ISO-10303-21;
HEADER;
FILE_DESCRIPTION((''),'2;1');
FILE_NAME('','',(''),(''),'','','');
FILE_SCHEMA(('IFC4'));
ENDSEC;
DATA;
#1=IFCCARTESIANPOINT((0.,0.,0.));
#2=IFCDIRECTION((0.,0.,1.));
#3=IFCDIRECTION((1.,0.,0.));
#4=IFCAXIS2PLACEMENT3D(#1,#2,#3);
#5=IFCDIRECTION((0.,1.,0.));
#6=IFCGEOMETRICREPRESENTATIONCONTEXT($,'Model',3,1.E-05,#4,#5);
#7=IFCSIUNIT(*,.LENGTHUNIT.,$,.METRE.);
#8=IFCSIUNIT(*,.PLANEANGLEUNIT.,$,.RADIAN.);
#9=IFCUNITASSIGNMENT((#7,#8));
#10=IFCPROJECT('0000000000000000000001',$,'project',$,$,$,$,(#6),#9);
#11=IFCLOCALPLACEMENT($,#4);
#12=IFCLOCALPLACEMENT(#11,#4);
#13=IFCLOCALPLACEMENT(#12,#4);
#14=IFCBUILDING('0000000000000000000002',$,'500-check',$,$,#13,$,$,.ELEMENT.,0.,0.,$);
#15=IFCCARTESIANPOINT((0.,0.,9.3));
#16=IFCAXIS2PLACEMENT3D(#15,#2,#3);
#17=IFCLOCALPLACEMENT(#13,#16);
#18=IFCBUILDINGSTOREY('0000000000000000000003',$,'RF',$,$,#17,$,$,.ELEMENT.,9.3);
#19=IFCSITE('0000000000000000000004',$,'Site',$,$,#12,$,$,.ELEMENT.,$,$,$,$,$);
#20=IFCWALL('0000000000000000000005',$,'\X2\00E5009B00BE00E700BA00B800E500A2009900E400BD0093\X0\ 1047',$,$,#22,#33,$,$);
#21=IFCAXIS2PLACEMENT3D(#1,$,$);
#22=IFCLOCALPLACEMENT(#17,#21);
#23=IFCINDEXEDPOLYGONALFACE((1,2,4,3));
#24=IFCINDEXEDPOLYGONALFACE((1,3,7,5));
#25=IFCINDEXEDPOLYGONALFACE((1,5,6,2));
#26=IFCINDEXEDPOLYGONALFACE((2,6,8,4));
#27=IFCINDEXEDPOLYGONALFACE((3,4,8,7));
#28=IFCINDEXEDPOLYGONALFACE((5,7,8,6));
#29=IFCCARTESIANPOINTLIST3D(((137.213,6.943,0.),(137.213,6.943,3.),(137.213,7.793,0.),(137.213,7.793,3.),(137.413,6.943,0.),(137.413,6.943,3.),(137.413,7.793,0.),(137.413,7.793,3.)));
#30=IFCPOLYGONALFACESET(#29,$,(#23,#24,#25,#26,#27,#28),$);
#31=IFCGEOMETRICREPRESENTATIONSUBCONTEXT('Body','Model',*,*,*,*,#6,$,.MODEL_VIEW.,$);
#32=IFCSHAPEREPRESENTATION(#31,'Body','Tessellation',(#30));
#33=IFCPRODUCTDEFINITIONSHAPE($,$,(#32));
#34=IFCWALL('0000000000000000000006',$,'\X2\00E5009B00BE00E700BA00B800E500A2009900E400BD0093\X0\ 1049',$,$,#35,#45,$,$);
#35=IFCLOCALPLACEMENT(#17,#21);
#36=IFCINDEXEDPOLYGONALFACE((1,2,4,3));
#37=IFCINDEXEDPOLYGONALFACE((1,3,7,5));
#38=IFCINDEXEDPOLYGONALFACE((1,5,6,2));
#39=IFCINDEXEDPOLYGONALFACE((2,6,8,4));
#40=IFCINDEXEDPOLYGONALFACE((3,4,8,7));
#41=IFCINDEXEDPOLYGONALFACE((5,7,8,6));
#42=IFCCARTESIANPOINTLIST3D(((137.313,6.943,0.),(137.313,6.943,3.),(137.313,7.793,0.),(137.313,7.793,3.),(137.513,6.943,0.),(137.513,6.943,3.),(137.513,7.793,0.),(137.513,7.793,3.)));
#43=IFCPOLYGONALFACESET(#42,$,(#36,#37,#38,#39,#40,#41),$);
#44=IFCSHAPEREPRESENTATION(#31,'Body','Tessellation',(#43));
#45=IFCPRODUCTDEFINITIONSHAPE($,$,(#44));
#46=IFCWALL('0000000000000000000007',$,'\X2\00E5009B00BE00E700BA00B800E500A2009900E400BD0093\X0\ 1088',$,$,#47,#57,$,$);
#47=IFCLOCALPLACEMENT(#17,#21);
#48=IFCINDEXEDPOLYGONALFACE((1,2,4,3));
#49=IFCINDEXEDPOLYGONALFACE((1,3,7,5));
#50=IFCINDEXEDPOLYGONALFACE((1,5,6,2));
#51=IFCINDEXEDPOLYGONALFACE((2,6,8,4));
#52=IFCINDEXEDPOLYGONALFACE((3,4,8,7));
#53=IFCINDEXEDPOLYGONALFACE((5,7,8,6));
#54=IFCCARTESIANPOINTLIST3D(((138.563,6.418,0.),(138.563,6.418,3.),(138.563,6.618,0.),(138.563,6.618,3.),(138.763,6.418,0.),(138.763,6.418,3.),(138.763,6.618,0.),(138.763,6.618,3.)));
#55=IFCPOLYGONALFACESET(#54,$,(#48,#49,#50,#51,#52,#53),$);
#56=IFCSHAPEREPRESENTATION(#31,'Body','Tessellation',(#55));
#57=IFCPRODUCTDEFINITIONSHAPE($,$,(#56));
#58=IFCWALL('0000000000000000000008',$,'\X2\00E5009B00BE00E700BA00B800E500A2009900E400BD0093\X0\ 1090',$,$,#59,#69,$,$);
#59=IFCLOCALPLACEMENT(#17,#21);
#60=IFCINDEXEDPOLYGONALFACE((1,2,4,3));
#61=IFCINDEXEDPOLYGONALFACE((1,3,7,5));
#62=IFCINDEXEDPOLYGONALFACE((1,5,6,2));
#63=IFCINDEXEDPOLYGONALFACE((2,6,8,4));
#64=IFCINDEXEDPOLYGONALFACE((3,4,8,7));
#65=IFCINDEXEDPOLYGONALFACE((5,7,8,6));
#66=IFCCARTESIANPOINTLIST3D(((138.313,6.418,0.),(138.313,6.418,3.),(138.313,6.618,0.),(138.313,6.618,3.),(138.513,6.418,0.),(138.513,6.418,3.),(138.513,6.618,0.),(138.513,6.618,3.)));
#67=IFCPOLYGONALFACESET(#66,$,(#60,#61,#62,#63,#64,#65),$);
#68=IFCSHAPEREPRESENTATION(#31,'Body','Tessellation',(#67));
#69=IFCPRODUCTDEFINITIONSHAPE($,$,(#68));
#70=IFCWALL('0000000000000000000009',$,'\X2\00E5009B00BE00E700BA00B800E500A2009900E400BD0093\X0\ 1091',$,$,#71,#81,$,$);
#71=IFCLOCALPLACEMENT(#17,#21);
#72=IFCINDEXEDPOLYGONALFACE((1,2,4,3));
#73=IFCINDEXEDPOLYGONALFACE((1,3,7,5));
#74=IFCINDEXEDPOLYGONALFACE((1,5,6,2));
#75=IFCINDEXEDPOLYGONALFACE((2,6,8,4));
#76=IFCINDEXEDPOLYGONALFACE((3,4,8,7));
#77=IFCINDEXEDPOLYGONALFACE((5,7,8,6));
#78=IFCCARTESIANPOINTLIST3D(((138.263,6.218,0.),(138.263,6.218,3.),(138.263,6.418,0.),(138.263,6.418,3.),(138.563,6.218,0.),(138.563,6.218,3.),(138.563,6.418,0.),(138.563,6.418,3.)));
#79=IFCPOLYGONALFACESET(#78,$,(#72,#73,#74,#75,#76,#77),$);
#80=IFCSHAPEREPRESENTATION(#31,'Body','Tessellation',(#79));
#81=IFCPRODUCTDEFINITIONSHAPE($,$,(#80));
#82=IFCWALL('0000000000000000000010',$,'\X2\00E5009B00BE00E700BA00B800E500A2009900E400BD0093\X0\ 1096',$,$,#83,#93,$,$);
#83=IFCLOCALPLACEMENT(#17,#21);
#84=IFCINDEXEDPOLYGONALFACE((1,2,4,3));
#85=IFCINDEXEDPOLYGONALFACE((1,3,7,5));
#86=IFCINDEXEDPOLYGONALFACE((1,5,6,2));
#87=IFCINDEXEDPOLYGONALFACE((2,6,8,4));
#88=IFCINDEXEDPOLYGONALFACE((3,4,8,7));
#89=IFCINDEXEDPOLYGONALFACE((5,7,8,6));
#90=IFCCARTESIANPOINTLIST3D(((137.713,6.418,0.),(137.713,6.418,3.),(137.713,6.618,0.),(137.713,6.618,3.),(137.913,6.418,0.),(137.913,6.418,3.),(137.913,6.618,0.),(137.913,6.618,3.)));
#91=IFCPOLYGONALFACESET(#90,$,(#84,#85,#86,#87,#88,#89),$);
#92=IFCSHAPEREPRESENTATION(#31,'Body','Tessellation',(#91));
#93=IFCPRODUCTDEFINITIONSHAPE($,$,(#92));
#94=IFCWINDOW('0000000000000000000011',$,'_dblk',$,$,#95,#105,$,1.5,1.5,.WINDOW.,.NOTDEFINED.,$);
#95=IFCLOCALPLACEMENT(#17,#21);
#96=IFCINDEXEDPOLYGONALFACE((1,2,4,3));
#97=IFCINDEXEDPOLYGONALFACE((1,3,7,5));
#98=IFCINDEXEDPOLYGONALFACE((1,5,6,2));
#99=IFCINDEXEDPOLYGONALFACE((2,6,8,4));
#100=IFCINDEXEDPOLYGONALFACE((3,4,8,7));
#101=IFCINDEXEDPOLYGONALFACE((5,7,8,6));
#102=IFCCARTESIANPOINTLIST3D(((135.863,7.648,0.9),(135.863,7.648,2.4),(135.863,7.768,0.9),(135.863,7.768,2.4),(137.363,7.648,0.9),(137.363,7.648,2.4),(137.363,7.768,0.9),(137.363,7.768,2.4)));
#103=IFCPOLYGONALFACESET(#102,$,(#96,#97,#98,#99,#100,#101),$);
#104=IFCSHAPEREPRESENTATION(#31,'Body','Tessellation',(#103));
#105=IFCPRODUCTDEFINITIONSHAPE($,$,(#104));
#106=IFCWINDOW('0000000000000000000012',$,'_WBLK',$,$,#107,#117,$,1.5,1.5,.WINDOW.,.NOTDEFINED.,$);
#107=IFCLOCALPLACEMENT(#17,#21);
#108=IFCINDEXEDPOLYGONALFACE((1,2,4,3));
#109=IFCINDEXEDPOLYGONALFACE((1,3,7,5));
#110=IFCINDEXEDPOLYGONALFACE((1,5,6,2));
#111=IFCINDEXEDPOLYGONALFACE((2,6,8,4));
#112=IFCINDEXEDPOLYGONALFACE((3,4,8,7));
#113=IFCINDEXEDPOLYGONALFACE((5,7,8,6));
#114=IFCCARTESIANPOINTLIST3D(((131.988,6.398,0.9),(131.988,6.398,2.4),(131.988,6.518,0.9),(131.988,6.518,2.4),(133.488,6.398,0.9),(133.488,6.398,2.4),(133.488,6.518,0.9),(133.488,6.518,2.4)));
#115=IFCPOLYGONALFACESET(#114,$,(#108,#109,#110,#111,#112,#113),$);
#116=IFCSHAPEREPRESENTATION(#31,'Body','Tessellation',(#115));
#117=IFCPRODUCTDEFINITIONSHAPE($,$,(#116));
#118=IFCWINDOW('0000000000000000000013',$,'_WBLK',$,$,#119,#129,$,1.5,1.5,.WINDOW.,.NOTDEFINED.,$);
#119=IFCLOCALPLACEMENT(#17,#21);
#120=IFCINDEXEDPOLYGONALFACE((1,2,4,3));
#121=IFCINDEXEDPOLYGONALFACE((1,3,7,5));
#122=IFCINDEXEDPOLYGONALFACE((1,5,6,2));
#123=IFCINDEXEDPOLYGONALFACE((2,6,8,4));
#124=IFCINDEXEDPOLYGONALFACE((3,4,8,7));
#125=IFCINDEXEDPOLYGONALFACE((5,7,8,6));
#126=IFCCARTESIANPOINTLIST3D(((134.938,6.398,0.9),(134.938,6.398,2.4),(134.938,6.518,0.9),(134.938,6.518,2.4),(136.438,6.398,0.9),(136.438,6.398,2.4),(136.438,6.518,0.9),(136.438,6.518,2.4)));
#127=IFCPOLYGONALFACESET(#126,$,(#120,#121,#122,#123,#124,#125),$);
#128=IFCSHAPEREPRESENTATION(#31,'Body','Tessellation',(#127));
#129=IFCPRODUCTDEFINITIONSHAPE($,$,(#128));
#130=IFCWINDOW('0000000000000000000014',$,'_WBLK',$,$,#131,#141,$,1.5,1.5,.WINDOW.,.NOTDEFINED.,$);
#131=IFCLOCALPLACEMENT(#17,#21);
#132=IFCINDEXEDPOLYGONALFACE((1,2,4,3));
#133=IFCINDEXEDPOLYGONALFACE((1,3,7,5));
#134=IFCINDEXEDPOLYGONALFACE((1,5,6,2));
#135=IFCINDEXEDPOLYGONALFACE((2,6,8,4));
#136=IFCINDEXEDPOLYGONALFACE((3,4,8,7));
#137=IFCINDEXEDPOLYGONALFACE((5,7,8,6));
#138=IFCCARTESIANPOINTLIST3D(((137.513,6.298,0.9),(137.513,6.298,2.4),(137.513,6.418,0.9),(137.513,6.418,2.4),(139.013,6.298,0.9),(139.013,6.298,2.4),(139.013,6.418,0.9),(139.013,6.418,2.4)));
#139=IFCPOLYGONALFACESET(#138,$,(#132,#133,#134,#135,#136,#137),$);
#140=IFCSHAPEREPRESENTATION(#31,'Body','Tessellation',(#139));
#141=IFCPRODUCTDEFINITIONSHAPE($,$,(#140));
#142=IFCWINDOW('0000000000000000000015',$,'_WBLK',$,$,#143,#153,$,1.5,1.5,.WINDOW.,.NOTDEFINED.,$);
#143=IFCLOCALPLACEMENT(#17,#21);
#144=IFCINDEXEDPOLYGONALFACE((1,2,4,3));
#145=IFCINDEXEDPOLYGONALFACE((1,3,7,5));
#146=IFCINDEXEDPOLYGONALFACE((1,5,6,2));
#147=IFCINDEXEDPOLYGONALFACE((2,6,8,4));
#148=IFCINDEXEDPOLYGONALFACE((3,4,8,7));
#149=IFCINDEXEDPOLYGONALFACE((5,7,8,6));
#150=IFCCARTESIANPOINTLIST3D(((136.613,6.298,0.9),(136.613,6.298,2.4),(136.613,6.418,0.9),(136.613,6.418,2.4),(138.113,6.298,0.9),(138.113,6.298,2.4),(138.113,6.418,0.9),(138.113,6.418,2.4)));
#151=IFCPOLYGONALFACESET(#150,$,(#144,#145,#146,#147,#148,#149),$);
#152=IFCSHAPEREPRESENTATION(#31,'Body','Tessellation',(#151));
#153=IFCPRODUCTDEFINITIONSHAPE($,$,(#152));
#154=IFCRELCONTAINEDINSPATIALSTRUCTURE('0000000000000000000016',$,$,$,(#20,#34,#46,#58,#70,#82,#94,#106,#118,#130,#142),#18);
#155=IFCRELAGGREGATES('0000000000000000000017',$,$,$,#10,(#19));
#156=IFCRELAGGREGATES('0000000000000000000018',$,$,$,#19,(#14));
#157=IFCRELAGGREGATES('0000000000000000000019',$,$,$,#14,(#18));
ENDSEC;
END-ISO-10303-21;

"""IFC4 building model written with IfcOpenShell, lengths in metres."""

from ifc_helpers import new_model, si_unit, direction, frame, frame_2d, origin_with_axes, place, context, subcontext, project, spatial, rectangle, extrude, element, save


model = new_model("IFC4")

# Units and contexts
model_context = context("Model", 3, precision=1e-05, world=origin_with_axes(), true_north=direction((0.0, 1.0, 0.0)))
body_context = subcontext(model_context, "Body", "Model", "MODEL_VIEW")
ifc_project = project(units=[si_unit("LENGTHUNIT", "METRE"), si_unit("PLANEANGLEUNIT", "RADIAN")], contexts=[model_context])

# Site, building, storey
placement = place(None, origin_with_axes())
site_placement = place(placement, origin_with_axes())
site = spatial("IfcSite", under=ifc_project, at=site_placement, Name="Site", CompositionType="ELEMENT")
building_placement = place(site_placement, origin_with_axes())
building = spatial("IfcBuilding", under=site, at=building_placement, Name="500-check", CompositionType="ELEMENT", ElevationOfRefHeight=0.0, ElevationOfTerrain=0.0)
storey_placement = place(building_placement, frame((0.0, 0.0, 9.3), z_axis=(0.0, 0.0, 1.0), x_axis=(1.0, 0.0, 0.0)))
storey = spatial("IfcBuildingStorey", under=building, at=storey_placement, Name="RF", CompositionType="ELEMENT", Elevation=9.3)

# Walls
for number, where, z_axis, x_axis, name in (
    (1, (137.313, 7.368, 0.0), (0.0, 0.0, 1.0), (0.0, -1.0, 0.0), "å\u009b¾çº¸å¢\u0099ä½\u0093 1047"),
    (2, (137.413, 7.368, 0.0), (0.0, 0.0, 1.0), (0.0, -1.0, 0.0), "å\u009b¾çº¸å¢\u0099ä½\u0093 1049"),
):
    element("IfcWall", number, at=place(storey_placement, frame(where, z_axis=z_axis, x_axis=x_axis)), inside=storey, Name=name, context=body_context, shape_type="SweptSolid", body=[
        extrude(rectangle(XDim=0.85, YDim=0.2, at=frame_2d((0.0, 0.0), x_axis=(1.0, 0.0, 0.0))), frame((0.0, 0.0, 0.0), z_axis=(0.0, 0.0, 1.0)), (0.0, 0.0, 1.0), 3.0),
    ])
for number, where, z_axis, x_axis, name in (
    (3, (138.663, 6.518, 0.0), (0.0, 0.0, 1.0), (1.0, 0.0, 0.0), "å\u009b¾çº¸å¢\u0099ä½\u0093 1088"),
    (4, (138.413, 6.518, 0.0), (0.0, 0.0, 1.0), (1.0, 0.0, 0.0), "å\u009b¾çº¸å¢\u0099ä½\u0093 1090"),
):
    element("IfcWall", number, at=place(storey_placement, frame(where, z_axis=z_axis, x_axis=x_axis)), inside=storey, Name=name, context=body_context, shape_type="SweptSolid", body=[
        extrude(rectangle(XDim=0.2, YDim=0.2, at=frame_2d((0.0, 0.0), x_axis=(1.0, 0.0, 0.0))), frame((0.0, 0.0, 0.0), z_axis=(0.0, 0.0, 1.0)), (0.0, 0.0, 1.0), 3.0),
    ])
wall_1_placement = place(storey_placement, frame((138.413, 6.318, 0.0), z_axis=(0.0, 0.0, 1.0), x_axis=(1.0, 0.0, 0.0)))
element("IfcWall", 5, at=wall_1_placement, inside=storey, Name="å\u009b¾çº¸å¢\u0099ä½\u0093 1091", context=body_context, shape_type="SweptSolid", body=[
    extrude(rectangle(XDim=0.3, YDim=0.2, at=frame_2d((0.0, 0.0), x_axis=(1.0, 0.0, 0.0))), frame((0.0, 0.0, 0.0), z_axis=(0.0, 0.0, 1.0)), (0.0, 0.0, 1.0), 3.0),
])
for number, where, z_axis, x_axis, name in (
    (6, (137.813, 6.518, 0.0), (0.0, 0.0, 1.0), (0.0, -1.0, 0.0), "å\u009b¾çº¸å¢\u0099ä½\u0093 1096"),
):
    element("IfcWall", number, at=place(storey_placement, frame(where, z_axis=z_axis, x_axis=x_axis)), inside=storey, Name=name, context=body_context, shape_type="SweptSolid", body=[
        extrude(rectangle(XDim=0.2, YDim=0.2, at=frame_2d((0.0, 0.0), x_axis=(1.0, 0.0, 0.0))), frame((0.0, 0.0, 0.0), z_axis=(0.0, 0.0, 1.0)), (0.0, 0.0, 1.0), 3.0),
    ])

# Windows
for number, where, z_axis, x_axis, name in (
    (7, (136.613, 7.708, 0.9), (0.0, 0.0, 1.0), (1.0, 0.0, 0.0), "_dblk"),
    (8, (132.738, 6.458, 0.9), (0.0, 0.0, 1.0), (1.0, 0.0, 0.0), "_WBLK"),
    (9, (135.688, 6.458, 0.9), (0.0, 0.0, 1.0), (1.0, 0.0, 0.0), "_WBLK"),
    (10, (138.263, 6.358, 0.9), (0.0, 0.0, 1.0), (1.0, 0.0, 0.0), "_WBLK"),
    (11, (137.363, 6.358, 0.9), (0.0, 0.0, 1.0), (1.0, 0.0, 0.0), "_WBLK"),
):
    element("IfcWindow", number, at=place(storey_placement, frame(where, z_axis=z_axis, x_axis=x_axis)), inside=storey, Name=name, OverallHeight=1.5, OverallWidth=1.5, PartitioningType="NOTDEFINED", PredefinedType="WINDOW", context=body_context, shape_type="SweptSolid", body=[
        extrude(rectangle(XDim=1.5, YDim=0.12, at=frame_2d((0.0, 0.0), x_axis=(1.0, 0.0, 0.0))), frame((0.0, 0.0, 0.0), z_axis=(0.0, 0.0, 1.0)), (0.0, 0.0, 1.0), 1.5),
    ])

save(model, "model.ifc")
